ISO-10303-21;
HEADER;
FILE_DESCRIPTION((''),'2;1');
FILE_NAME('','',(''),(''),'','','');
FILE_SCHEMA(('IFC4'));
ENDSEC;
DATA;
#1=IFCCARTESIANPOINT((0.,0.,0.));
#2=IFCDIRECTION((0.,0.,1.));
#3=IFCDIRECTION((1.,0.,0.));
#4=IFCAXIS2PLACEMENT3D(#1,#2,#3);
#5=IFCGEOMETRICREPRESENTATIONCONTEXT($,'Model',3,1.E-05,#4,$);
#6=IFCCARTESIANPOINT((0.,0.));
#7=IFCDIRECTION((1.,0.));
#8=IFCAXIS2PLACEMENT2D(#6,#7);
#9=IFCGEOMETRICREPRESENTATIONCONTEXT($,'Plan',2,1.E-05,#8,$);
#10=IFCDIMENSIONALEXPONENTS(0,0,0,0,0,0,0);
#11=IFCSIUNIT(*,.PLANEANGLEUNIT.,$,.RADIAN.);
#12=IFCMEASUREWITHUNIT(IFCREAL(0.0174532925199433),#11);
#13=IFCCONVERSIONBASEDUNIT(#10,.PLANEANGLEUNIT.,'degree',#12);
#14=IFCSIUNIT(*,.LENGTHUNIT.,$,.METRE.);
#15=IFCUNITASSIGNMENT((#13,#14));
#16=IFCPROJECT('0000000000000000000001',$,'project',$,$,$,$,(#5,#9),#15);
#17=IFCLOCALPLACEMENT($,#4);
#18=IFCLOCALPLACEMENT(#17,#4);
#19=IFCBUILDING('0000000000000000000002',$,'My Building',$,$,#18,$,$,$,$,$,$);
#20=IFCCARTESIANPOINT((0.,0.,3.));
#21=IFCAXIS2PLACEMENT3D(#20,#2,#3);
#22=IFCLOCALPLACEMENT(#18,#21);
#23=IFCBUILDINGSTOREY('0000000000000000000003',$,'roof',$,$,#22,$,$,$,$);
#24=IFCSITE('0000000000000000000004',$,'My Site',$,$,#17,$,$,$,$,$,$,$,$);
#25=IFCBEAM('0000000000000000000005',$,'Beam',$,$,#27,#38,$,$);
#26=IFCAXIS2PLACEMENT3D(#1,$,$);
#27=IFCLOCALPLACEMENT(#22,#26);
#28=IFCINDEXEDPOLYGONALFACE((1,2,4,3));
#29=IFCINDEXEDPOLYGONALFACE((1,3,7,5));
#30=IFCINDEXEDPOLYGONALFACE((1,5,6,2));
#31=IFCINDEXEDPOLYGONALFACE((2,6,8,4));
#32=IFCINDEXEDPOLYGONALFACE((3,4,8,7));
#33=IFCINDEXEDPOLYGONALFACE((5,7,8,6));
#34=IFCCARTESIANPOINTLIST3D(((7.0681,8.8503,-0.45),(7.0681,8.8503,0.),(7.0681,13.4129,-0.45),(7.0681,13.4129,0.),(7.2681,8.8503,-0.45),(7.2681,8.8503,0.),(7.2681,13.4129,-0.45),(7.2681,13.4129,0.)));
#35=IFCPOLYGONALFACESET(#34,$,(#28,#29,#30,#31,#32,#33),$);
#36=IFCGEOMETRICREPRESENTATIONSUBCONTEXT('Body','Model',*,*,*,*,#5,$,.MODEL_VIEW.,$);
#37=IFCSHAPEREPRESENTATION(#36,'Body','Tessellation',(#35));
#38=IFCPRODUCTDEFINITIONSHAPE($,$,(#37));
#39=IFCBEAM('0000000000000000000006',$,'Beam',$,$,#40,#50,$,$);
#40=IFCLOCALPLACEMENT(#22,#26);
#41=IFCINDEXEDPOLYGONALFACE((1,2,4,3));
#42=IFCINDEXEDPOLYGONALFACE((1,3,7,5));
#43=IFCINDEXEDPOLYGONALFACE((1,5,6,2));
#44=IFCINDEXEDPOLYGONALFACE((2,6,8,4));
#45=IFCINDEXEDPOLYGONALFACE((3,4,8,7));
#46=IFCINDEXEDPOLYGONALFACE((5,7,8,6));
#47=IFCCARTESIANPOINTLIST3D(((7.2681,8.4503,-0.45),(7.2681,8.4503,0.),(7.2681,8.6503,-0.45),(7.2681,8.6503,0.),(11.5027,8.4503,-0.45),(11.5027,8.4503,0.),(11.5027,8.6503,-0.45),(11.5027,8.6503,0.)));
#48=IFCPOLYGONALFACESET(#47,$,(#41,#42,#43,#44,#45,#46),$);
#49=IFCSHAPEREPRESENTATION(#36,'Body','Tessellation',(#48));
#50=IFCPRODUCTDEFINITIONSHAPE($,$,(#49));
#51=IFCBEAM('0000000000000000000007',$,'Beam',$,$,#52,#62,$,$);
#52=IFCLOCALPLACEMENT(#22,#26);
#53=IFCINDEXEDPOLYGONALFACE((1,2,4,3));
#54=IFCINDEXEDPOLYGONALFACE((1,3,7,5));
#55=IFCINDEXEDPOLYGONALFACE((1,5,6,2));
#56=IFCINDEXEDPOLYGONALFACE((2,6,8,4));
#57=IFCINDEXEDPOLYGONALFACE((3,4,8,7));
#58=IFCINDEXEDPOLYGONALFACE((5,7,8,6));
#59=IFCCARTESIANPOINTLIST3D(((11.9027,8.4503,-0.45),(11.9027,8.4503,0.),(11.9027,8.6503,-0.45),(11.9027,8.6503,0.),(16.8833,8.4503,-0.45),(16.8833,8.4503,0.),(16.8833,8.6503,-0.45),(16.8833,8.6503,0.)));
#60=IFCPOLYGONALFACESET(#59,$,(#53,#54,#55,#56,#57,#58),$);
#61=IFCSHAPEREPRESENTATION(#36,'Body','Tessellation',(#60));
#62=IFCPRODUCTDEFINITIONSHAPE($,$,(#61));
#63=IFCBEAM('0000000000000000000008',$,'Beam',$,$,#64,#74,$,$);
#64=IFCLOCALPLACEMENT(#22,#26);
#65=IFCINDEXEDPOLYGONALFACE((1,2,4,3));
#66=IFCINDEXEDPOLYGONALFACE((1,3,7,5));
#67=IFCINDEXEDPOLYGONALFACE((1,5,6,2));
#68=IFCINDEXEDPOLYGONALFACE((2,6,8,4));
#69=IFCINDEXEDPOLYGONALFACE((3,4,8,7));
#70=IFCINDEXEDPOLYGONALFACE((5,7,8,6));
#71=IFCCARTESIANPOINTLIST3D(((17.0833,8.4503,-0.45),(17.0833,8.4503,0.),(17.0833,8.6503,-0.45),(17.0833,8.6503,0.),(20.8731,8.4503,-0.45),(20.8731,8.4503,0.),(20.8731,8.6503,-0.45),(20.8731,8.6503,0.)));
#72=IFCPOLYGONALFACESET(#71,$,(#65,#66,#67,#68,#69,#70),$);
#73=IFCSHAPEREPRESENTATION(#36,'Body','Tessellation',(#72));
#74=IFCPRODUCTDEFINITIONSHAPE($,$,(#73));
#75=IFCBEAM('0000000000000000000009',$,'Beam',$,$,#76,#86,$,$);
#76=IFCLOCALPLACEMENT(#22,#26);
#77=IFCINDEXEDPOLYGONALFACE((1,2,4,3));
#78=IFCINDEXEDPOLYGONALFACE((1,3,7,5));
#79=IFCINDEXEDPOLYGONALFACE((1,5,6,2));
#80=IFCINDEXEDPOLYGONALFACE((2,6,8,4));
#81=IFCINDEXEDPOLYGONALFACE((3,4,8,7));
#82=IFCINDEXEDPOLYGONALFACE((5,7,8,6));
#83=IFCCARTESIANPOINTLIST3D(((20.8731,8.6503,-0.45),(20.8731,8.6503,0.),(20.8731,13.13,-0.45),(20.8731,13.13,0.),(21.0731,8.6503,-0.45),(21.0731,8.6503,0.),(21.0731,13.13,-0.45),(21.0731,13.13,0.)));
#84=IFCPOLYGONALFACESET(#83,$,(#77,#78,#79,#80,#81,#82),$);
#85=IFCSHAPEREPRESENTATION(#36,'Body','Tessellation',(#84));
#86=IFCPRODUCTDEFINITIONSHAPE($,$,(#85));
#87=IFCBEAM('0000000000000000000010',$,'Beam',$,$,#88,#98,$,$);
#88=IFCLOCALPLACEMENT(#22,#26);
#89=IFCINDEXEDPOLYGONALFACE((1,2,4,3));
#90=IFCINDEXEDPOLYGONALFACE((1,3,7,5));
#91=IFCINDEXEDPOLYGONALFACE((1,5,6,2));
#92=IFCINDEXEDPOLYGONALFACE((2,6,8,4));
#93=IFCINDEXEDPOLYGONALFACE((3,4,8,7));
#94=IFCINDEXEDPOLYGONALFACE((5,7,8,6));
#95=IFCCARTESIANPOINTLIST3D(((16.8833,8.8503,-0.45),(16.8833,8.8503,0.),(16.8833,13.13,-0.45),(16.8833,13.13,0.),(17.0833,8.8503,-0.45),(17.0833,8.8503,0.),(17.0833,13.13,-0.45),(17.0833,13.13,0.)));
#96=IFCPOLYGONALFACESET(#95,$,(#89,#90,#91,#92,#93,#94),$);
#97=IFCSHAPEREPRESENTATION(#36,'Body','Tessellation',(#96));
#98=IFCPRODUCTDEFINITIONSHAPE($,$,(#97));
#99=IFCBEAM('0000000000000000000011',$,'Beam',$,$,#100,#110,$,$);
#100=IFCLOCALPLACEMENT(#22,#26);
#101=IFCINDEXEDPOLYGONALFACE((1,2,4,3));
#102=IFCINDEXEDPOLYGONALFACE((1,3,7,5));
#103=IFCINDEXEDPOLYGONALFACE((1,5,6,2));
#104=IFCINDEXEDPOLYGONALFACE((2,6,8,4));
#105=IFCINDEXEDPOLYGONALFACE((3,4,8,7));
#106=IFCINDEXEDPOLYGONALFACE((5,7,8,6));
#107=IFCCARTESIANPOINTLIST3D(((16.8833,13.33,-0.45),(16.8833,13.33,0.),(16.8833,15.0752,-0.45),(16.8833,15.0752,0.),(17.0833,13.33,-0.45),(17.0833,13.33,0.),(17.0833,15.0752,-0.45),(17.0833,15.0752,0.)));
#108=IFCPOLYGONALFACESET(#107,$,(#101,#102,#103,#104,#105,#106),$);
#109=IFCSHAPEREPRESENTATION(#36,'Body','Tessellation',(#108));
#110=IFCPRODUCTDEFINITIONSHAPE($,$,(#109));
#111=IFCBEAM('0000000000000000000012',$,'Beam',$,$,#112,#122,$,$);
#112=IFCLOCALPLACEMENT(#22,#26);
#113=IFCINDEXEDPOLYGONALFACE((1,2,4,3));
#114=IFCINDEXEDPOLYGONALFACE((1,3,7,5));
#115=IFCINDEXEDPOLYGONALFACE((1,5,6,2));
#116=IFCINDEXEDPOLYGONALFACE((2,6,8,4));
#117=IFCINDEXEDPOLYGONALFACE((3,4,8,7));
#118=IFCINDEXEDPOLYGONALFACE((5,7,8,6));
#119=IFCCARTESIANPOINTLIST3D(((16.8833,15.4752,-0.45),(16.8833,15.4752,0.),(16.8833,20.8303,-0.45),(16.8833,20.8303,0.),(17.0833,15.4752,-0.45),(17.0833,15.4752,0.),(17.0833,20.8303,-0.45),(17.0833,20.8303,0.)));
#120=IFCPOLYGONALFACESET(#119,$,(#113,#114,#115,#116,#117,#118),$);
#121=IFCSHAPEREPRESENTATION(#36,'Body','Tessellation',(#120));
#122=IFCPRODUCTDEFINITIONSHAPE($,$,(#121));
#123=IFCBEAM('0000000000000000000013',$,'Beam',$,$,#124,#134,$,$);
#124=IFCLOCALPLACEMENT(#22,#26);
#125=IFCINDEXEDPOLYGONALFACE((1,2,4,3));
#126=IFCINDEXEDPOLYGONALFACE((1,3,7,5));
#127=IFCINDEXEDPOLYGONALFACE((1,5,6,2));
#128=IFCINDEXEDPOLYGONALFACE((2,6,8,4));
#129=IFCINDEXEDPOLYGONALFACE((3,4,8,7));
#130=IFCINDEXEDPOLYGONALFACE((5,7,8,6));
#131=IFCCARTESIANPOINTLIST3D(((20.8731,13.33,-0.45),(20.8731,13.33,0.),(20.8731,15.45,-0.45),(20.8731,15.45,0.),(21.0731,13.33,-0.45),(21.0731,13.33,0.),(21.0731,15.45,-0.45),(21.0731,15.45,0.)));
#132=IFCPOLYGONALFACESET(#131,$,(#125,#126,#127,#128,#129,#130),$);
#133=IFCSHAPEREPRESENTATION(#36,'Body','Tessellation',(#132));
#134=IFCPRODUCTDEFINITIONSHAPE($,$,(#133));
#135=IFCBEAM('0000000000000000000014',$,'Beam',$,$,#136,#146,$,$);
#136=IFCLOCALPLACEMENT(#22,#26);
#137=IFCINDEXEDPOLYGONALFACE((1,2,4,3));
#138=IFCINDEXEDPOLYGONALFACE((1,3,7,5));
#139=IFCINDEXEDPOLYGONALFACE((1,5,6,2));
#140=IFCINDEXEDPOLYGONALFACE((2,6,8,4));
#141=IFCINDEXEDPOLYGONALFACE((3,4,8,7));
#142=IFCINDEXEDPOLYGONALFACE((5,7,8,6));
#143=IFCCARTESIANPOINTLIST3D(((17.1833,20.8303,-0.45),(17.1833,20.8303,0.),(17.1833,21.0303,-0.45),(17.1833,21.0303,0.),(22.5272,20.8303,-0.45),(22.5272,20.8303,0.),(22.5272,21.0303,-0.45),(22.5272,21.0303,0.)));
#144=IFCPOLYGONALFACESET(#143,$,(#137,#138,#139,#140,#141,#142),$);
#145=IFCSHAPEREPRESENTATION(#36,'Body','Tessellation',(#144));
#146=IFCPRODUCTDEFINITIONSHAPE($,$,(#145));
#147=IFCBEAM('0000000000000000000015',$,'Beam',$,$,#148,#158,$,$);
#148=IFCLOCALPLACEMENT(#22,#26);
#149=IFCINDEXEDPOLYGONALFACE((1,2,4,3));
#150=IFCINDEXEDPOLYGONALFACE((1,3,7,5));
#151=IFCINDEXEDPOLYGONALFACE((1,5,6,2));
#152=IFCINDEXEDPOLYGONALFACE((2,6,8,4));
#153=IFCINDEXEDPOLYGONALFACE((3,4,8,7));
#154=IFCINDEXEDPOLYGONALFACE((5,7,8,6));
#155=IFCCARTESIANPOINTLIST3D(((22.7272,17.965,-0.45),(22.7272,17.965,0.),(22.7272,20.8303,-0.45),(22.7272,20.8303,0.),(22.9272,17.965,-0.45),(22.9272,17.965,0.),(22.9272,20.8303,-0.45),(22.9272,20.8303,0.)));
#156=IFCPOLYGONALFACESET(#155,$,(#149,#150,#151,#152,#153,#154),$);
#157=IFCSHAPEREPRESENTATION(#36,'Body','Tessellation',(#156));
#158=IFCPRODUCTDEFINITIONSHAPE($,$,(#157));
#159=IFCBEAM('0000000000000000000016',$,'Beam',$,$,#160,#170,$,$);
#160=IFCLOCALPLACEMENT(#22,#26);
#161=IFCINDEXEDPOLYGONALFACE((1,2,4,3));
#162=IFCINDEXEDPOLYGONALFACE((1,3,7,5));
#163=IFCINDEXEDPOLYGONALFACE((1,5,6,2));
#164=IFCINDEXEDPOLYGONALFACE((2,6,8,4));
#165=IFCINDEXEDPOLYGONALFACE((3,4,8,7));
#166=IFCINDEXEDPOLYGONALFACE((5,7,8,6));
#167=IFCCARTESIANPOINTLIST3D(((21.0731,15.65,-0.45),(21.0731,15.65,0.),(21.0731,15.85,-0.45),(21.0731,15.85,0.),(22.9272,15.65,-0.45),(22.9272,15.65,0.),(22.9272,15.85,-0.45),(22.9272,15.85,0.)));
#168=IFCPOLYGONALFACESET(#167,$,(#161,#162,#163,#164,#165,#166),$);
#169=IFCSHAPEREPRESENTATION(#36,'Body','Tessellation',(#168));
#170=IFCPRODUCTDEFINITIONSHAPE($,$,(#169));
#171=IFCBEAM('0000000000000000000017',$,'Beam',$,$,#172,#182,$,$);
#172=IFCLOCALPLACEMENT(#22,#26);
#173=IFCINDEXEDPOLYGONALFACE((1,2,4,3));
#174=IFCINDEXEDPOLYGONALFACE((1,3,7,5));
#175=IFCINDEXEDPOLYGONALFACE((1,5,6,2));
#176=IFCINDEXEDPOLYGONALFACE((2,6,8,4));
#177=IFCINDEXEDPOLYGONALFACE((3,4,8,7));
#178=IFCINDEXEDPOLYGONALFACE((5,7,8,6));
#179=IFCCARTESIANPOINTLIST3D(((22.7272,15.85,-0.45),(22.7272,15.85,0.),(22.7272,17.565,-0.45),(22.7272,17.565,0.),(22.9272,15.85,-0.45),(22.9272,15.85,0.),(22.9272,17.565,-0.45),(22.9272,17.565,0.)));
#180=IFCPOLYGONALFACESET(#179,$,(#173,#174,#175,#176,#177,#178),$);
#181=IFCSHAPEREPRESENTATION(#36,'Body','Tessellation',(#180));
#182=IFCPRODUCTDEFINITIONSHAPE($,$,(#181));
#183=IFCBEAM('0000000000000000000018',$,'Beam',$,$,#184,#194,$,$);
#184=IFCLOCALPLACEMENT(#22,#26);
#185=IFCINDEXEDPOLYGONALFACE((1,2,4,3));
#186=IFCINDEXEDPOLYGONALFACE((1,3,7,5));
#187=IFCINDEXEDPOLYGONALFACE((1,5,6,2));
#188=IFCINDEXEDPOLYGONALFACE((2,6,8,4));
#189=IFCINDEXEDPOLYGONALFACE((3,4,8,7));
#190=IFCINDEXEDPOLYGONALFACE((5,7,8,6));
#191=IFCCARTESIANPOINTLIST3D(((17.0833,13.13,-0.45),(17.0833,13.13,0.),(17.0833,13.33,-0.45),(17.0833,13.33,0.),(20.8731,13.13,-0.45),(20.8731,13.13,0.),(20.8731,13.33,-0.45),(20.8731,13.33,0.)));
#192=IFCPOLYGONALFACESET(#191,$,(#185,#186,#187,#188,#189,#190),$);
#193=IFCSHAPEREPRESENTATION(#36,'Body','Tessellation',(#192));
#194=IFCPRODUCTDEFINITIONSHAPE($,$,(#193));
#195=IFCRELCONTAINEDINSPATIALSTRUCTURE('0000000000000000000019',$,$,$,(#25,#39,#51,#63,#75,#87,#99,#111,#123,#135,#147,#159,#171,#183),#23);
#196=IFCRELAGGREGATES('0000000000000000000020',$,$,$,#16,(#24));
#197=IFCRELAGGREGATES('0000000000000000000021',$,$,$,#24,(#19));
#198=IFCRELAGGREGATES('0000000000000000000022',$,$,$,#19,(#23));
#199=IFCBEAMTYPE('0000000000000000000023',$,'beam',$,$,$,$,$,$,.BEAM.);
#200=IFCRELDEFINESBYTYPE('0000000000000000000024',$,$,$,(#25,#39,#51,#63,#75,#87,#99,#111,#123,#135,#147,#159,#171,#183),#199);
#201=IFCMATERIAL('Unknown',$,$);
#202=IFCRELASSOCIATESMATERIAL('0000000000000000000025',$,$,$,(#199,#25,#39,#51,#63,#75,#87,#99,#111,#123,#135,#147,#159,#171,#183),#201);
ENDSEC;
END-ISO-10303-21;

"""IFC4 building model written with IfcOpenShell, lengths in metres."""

from ifc_helpers import new_model, entity, si_unit, converted_unit, frame, origin_with_axes, origin_2d_with_axis, place, context, subcontext, project, spatial, rectangle, extrude, material, material_profile, profile_set, profile_usage, type_object, element, save


model = new_model("IFC4")

# Units and contexts
model_context = context("Model", 3, precision=1e-05, world=origin_with_axes())
plan_context = context("Plan", 2, precision=1e-05, world=origin_2d_with_axis())
body_context = subcontext(model_context, "Body", "Model", "MODEL_VIEW")
ifc_project = project(units=[converted_unit("PLANEANGLEUNIT", "degree", entity("IfcReal", 0.0174532925199433), si_unit("PLANEANGLEUNIT", "RADIAN"), dimensions=[0, 0, 0, 0, 0, 0, 0]), si_unit("LENGTHUNIT", "METRE")], contexts=[model_context, plan_context])

# Site, building, storey
site_placement = place(None, origin_with_axes())
site = spatial("IfcSite", under=ifc_project, at=site_placement, Name="My Site")
building_placement = place(site_placement, origin_with_axes())
building = spatial("IfcBuilding", under=site, at=building_placement, Name="My Building")
storey_placement = place(building_placement, frame((0.0, 0.0, 3.0), z_axis=(0.0, 0.0, 1.0), x_axis=(1.0, 0.0, 0.0)))
storey = spatial("IfcBuildingStorey", under=building, at=storey_placement, Name="roof")

# Beams
ifc_material = material(Name="Unknown")
ifc_material_profile = material_profile(ifc_material, rectangle(XDim=0.2, YDim=0.45))
ifc_profile_set = profile_set([ifc_material_profile])
ifc_profile_usage_1 = profile_usage(ifc_profile_set, cardinal=9)
beam_type = type_object("IfcBeamType", Name="beam", PredefinedType="BEAM", material=ifc_profile_set)
beam_1_placement = place(storey_placement, frame((7.0681, 13.4129, 0.0), z_axis=(0.0, -1.0, 0.0), x_axis=(1.0, 0.0, 0.0)))
element("IfcBeam", 1, at=beam_1_placement, inside=storey, type_object=beam_type, material=ifc_profile_usage_1, Name="Beam", context=body_context, shape_type="SweptSolid", body=[
    extrude(rectangle(XDim=0.2, YDim=0.45), frame((0.1, -0.225, 0.0), z_axis=(0.0, 0.0, 1.0), x_axis=(1.0, 0.0, 0.0)), (0.0, 0.0, 1.0), 4.5626),
])
ifc_profile_usage_2 = profile_usage(ifc_profile_set, cardinal=9)
beam_2_placement = place(storey_placement, frame((7.2681, 8.4503, 0.0), z_axis=(1.0, 0.0, 0.0), x_axis=(0.0, 1.0, 0.0)))
element("IfcBeam", 2, at=beam_2_placement, inside=storey, type_object=beam_type, material=ifc_profile_usage_2, Name="Beam", context=body_context, shape_type="SweptSolid", body=[
    extrude(rectangle(XDim=0.2, YDim=0.45), frame((0.1, -0.225, 0.0), z_axis=(0.0, 0.0, 1.0), x_axis=(1.0, 0.0, 0.0)), (0.0, 0.0, 1.0), 4.2345),
])
ifc_profile_usage_3 = profile_usage(ifc_profile_set, cardinal=9)
beam_3_placement = place(storey_placement, frame((11.9027, 8.4503, 0.0), z_axis=(1.0, 0.0, 0.0), x_axis=(0.0, 1.0, 0.0)))
element("IfcBeam", 3, at=beam_3_placement, inside=storey, type_object=beam_type, material=ifc_profile_usage_3, Name="Beam", context=body_context, shape_type="SweptSolid", body=[
    extrude(rectangle(XDim=0.2, YDim=0.45), frame((0.1, -0.225, 0.0), z_axis=(0.0, 0.0, 1.0), x_axis=(1.0, 0.0, 0.0)), (0.0, 0.0, 1.0), 4.9806),
])
ifc_profile_usage_4 = profile_usage(ifc_profile_set, cardinal=9)
beam_4_placement = place(storey_placement, frame((17.0833, 8.4503, 0.0), z_axis=(1.0, 0.0, 0.0), x_axis=(0.0, 1.0, 0.0)))
element("IfcBeam", 4, at=beam_4_placement, inside=storey, type_object=beam_type, material=ifc_profile_usage_4, Name="Beam", context=body_context, shape_type="SweptSolid", body=[
    extrude(rectangle(XDim=0.2, YDim=0.45), frame((0.1, -0.225, 0.0), z_axis=(0.0, 0.0, 1.0), x_axis=(1.0, 0.0, 0.0)), (0.0, 0.0, 1.0), 3.7898),
])
ifc_profile_usage_5 = profile_usage(ifc_profile_set, cardinal=9)
beam_5_placement = place(storey_placement, frame((21.0731, 8.6503, 0.0), z_axis=(0.0, 1.0, 0.0), x_axis=(-1.0, 0.0, 0.0)))
element("IfcBeam", 5, at=beam_5_placement, inside=storey, type_object=beam_type, material=ifc_profile_usage_5, Name="Beam", context=body_context, shape_type="SweptSolid", body=[
    extrude(rectangle(XDim=0.2, YDim=0.45), frame((0.1, -0.225, 0.0), z_axis=(0.0, 0.0, 1.0), x_axis=(1.0, 0.0, 0.0)), (0.0, 0.0, 1.0), 4.4796),
])
ifc_profile_usage_6 = profile_usage(ifc_profile_set, cardinal=9)
beam_6_placement = place(storey_placement, frame((17.0833, 8.8503, 0.0), z_axis=(0.0, 1.0, 0.0), x_axis=(-1.0, 0.0, 0.0)))
element("IfcBeam", 6, at=beam_6_placement, inside=storey, type_object=beam_type, material=ifc_profile_usage_6, Name="Beam", context=body_context, shape_type="SweptSolid", body=[
    extrude(rectangle(XDim=0.2, YDim=0.45), frame((0.1, -0.225, 0.0), z_axis=(0.0, 0.0, 1.0), x_axis=(1.0, 0.0, 0.0)), (0.0, 0.0, 1.0), 4.2796),
])
ifc_profile_usage_7 = profile_usage(ifc_profile_set, cardinal=9)
beam_7_placement = place(storey_placement, frame((17.0833, 13.33, 0.0), z_axis=(0.0, 1.0, 0.0), x_axis=(-1.0, 0.0, 0.0)))
element("IfcBeam", 7, at=beam_7_placement, inside=storey, type_object=beam_type, material=ifc_profile_usage_7, Name="Beam", context=body_context, shape_type="SweptSolid", body=[
    extrude(rectangle(XDim=0.2, YDim=0.45), frame((0.1, -0.225, 0.0), z_axis=(0.0, 0.0, 1.0), x_axis=(1.0, 0.0, 0.0)), (0.0, 0.0, 1.0), 1.7452),
])
ifc_profile_usage_8 = profile_usage(ifc_profile_set, cardinal=9)
beam_8_placement = place(storey_placement, frame((17.0833, 15.4752, 0.0), z_axis=(0.0, 1.0, 0.0), x_axis=(-1.0, 0.0, 0.0)))
element("IfcBeam", 8, at=beam_8_placement, inside=storey, type_object=beam_type, material=ifc_profile_usage_8, Name="Beam", context=body_context, shape_type="SweptSolid", body=[
    extrude(rectangle(XDim=0.2, YDim=0.45), frame((0.1, -0.225, 0.0), z_axis=(0.0, 0.0, 1.0), x_axis=(1.0, 0.0, 0.0)), (0.0, 0.0, 1.0), 5.3551),
])
ifc_profile_usage_9 = profile_usage(ifc_profile_set, cardinal=9)
beam_9_placement = place(storey_placement, frame((21.0731, 13.33, 0.0), z_axis=(0.0, 1.0, 0.0), x_axis=(-1.0, 0.0, 0.0)))
element("IfcBeam", 9, at=beam_9_placement, inside=storey, type_object=beam_type, material=ifc_profile_usage_9, Name="Beam", context=body_context, shape_type="SweptSolid", body=[
    extrude(rectangle(XDim=0.2, YDim=0.45), frame((0.1, -0.225, 0.0), z_axis=(0.0, 0.0, 1.0), x_axis=(1.0, 0.0, 0.0)), (0.0, 0.0, 1.0), 2.12),
])
ifc_profile_usage_10 = profile_usage(ifc_profile_set, cardinal=9)
beam_10_placement = place(storey_placement, frame((22.5272, 21.0303, 0.0), z_axis=(-1.0, 0.000001, 0.0), x_axis=(-0.000001, -1.0, 0.0)))
element("IfcBeam", 10, at=beam_10_placement, inside=storey, type_object=beam_type, material=ifc_profile_usage_10, Name="Beam", context=body_context, shape_type="SweptSolid", body=[
    extrude(rectangle(XDim=0.2, YDim=0.45), frame((0.1, -0.225, 0.0), z_axis=(0.0, 0.0, 1.0), x_axis=(1.0, 0.0, 0.0)), (0.0, 0.0, 1.0), 5.3439),
])
ifc_profile_usage_11 = profile_usage(ifc_profile_set, cardinal=9)
beam_11_placement = place(storey_placement, frame((22.9272, 17.965, 0.0), z_axis=(0.0, 1.0, 0.0), x_axis=(-1.0, 0.0, 0.0)))
element("IfcBeam", 11, at=beam_11_placement, inside=storey, type_object=beam_type, material=ifc_profile_usage_11, Name="Beam", context=body_context, shape_type="SweptSolid", body=[
    extrude(rectangle(XDim=0.2, YDim=0.45), frame((0.1, -0.225, 0.0), z_axis=(0.0, 0.0, 1.0), x_axis=(1.0, 0.0, 0.0)), (0.0, 0.0, 1.0), 2.8654),
])
ifc_profile_usage_12 = profile_usage(ifc_profile_set, cardinal=9)
beam_12_placement = place(storey_placement, frame((21.0731, 15.65, 0.0), z_axis=(1.0, 0.0, 0.0), x_axis=(0.0, 1.0, 0.0)))
element("IfcBeam", 12, at=beam_12_placement, inside=storey, type_object=beam_type, material=ifc_profile_usage_12, Name="Beam", context=body_context, shape_type="SweptSolid", body=[
    extrude(rectangle(XDim=0.2, YDim=0.45), frame((0.1, -0.225, 0.0), z_axis=(0.0, 0.0, 1.0), x_axis=(1.0, 0.0, 0.0)), (0.0, 0.0, 1.0), 1.8541),
])
ifc_profile_usage_13 = profile_usage(ifc_profile_set, cardinal=7)
beam_13_placement = place(storey_placement, frame((22.9272, 17.565, 0.0), z_axis=(-0.000001, -1.0, 0.0), x_axis=(1.0, -0.000001, 0.0)))
element("IfcBeam", 13, at=beam_13_placement, inside=storey, type_object=beam_type, material=ifc_profile_usage_13, Name="Beam", context=body_context, shape_type="SweptSolid", body=[
    extrude(rectangle(XDim=0.2, YDim=0.45), frame((-0.1, -0.225, 0.0), z_axis=(0.0, 0.0, 1.0), x_axis=(1.0, 0.0, 0.0)), (0.0, 0.0, 1.0), 1.715),
])
ifc_profile_usage_14 = profile_usage(ifc_profile_set, cardinal=9)
beam_14_placement = place(storey_placement, frame((17.0833, 13.13, 0.0), z_axis=(1.0, 0.0, 0.0), x_axis=(0.0, 1.0, 0.0)))
element("IfcBeam", 14, at=beam_14_placement, inside=storey, type_object=beam_type, material=ifc_profile_usage_14, Name="Beam", context=body_context, shape_type="SweptSolid", body=[
    extrude(rectangle(XDim=0.2, YDim=0.45), frame((0.1, -0.225, 0.0), z_axis=(0.0, 0.0, 1.0), x_axis=(1.0, 0.0, 0.0)), (0.0, 0.0, 1.0), 3.7898),
])

save(model, "model.ifc")
